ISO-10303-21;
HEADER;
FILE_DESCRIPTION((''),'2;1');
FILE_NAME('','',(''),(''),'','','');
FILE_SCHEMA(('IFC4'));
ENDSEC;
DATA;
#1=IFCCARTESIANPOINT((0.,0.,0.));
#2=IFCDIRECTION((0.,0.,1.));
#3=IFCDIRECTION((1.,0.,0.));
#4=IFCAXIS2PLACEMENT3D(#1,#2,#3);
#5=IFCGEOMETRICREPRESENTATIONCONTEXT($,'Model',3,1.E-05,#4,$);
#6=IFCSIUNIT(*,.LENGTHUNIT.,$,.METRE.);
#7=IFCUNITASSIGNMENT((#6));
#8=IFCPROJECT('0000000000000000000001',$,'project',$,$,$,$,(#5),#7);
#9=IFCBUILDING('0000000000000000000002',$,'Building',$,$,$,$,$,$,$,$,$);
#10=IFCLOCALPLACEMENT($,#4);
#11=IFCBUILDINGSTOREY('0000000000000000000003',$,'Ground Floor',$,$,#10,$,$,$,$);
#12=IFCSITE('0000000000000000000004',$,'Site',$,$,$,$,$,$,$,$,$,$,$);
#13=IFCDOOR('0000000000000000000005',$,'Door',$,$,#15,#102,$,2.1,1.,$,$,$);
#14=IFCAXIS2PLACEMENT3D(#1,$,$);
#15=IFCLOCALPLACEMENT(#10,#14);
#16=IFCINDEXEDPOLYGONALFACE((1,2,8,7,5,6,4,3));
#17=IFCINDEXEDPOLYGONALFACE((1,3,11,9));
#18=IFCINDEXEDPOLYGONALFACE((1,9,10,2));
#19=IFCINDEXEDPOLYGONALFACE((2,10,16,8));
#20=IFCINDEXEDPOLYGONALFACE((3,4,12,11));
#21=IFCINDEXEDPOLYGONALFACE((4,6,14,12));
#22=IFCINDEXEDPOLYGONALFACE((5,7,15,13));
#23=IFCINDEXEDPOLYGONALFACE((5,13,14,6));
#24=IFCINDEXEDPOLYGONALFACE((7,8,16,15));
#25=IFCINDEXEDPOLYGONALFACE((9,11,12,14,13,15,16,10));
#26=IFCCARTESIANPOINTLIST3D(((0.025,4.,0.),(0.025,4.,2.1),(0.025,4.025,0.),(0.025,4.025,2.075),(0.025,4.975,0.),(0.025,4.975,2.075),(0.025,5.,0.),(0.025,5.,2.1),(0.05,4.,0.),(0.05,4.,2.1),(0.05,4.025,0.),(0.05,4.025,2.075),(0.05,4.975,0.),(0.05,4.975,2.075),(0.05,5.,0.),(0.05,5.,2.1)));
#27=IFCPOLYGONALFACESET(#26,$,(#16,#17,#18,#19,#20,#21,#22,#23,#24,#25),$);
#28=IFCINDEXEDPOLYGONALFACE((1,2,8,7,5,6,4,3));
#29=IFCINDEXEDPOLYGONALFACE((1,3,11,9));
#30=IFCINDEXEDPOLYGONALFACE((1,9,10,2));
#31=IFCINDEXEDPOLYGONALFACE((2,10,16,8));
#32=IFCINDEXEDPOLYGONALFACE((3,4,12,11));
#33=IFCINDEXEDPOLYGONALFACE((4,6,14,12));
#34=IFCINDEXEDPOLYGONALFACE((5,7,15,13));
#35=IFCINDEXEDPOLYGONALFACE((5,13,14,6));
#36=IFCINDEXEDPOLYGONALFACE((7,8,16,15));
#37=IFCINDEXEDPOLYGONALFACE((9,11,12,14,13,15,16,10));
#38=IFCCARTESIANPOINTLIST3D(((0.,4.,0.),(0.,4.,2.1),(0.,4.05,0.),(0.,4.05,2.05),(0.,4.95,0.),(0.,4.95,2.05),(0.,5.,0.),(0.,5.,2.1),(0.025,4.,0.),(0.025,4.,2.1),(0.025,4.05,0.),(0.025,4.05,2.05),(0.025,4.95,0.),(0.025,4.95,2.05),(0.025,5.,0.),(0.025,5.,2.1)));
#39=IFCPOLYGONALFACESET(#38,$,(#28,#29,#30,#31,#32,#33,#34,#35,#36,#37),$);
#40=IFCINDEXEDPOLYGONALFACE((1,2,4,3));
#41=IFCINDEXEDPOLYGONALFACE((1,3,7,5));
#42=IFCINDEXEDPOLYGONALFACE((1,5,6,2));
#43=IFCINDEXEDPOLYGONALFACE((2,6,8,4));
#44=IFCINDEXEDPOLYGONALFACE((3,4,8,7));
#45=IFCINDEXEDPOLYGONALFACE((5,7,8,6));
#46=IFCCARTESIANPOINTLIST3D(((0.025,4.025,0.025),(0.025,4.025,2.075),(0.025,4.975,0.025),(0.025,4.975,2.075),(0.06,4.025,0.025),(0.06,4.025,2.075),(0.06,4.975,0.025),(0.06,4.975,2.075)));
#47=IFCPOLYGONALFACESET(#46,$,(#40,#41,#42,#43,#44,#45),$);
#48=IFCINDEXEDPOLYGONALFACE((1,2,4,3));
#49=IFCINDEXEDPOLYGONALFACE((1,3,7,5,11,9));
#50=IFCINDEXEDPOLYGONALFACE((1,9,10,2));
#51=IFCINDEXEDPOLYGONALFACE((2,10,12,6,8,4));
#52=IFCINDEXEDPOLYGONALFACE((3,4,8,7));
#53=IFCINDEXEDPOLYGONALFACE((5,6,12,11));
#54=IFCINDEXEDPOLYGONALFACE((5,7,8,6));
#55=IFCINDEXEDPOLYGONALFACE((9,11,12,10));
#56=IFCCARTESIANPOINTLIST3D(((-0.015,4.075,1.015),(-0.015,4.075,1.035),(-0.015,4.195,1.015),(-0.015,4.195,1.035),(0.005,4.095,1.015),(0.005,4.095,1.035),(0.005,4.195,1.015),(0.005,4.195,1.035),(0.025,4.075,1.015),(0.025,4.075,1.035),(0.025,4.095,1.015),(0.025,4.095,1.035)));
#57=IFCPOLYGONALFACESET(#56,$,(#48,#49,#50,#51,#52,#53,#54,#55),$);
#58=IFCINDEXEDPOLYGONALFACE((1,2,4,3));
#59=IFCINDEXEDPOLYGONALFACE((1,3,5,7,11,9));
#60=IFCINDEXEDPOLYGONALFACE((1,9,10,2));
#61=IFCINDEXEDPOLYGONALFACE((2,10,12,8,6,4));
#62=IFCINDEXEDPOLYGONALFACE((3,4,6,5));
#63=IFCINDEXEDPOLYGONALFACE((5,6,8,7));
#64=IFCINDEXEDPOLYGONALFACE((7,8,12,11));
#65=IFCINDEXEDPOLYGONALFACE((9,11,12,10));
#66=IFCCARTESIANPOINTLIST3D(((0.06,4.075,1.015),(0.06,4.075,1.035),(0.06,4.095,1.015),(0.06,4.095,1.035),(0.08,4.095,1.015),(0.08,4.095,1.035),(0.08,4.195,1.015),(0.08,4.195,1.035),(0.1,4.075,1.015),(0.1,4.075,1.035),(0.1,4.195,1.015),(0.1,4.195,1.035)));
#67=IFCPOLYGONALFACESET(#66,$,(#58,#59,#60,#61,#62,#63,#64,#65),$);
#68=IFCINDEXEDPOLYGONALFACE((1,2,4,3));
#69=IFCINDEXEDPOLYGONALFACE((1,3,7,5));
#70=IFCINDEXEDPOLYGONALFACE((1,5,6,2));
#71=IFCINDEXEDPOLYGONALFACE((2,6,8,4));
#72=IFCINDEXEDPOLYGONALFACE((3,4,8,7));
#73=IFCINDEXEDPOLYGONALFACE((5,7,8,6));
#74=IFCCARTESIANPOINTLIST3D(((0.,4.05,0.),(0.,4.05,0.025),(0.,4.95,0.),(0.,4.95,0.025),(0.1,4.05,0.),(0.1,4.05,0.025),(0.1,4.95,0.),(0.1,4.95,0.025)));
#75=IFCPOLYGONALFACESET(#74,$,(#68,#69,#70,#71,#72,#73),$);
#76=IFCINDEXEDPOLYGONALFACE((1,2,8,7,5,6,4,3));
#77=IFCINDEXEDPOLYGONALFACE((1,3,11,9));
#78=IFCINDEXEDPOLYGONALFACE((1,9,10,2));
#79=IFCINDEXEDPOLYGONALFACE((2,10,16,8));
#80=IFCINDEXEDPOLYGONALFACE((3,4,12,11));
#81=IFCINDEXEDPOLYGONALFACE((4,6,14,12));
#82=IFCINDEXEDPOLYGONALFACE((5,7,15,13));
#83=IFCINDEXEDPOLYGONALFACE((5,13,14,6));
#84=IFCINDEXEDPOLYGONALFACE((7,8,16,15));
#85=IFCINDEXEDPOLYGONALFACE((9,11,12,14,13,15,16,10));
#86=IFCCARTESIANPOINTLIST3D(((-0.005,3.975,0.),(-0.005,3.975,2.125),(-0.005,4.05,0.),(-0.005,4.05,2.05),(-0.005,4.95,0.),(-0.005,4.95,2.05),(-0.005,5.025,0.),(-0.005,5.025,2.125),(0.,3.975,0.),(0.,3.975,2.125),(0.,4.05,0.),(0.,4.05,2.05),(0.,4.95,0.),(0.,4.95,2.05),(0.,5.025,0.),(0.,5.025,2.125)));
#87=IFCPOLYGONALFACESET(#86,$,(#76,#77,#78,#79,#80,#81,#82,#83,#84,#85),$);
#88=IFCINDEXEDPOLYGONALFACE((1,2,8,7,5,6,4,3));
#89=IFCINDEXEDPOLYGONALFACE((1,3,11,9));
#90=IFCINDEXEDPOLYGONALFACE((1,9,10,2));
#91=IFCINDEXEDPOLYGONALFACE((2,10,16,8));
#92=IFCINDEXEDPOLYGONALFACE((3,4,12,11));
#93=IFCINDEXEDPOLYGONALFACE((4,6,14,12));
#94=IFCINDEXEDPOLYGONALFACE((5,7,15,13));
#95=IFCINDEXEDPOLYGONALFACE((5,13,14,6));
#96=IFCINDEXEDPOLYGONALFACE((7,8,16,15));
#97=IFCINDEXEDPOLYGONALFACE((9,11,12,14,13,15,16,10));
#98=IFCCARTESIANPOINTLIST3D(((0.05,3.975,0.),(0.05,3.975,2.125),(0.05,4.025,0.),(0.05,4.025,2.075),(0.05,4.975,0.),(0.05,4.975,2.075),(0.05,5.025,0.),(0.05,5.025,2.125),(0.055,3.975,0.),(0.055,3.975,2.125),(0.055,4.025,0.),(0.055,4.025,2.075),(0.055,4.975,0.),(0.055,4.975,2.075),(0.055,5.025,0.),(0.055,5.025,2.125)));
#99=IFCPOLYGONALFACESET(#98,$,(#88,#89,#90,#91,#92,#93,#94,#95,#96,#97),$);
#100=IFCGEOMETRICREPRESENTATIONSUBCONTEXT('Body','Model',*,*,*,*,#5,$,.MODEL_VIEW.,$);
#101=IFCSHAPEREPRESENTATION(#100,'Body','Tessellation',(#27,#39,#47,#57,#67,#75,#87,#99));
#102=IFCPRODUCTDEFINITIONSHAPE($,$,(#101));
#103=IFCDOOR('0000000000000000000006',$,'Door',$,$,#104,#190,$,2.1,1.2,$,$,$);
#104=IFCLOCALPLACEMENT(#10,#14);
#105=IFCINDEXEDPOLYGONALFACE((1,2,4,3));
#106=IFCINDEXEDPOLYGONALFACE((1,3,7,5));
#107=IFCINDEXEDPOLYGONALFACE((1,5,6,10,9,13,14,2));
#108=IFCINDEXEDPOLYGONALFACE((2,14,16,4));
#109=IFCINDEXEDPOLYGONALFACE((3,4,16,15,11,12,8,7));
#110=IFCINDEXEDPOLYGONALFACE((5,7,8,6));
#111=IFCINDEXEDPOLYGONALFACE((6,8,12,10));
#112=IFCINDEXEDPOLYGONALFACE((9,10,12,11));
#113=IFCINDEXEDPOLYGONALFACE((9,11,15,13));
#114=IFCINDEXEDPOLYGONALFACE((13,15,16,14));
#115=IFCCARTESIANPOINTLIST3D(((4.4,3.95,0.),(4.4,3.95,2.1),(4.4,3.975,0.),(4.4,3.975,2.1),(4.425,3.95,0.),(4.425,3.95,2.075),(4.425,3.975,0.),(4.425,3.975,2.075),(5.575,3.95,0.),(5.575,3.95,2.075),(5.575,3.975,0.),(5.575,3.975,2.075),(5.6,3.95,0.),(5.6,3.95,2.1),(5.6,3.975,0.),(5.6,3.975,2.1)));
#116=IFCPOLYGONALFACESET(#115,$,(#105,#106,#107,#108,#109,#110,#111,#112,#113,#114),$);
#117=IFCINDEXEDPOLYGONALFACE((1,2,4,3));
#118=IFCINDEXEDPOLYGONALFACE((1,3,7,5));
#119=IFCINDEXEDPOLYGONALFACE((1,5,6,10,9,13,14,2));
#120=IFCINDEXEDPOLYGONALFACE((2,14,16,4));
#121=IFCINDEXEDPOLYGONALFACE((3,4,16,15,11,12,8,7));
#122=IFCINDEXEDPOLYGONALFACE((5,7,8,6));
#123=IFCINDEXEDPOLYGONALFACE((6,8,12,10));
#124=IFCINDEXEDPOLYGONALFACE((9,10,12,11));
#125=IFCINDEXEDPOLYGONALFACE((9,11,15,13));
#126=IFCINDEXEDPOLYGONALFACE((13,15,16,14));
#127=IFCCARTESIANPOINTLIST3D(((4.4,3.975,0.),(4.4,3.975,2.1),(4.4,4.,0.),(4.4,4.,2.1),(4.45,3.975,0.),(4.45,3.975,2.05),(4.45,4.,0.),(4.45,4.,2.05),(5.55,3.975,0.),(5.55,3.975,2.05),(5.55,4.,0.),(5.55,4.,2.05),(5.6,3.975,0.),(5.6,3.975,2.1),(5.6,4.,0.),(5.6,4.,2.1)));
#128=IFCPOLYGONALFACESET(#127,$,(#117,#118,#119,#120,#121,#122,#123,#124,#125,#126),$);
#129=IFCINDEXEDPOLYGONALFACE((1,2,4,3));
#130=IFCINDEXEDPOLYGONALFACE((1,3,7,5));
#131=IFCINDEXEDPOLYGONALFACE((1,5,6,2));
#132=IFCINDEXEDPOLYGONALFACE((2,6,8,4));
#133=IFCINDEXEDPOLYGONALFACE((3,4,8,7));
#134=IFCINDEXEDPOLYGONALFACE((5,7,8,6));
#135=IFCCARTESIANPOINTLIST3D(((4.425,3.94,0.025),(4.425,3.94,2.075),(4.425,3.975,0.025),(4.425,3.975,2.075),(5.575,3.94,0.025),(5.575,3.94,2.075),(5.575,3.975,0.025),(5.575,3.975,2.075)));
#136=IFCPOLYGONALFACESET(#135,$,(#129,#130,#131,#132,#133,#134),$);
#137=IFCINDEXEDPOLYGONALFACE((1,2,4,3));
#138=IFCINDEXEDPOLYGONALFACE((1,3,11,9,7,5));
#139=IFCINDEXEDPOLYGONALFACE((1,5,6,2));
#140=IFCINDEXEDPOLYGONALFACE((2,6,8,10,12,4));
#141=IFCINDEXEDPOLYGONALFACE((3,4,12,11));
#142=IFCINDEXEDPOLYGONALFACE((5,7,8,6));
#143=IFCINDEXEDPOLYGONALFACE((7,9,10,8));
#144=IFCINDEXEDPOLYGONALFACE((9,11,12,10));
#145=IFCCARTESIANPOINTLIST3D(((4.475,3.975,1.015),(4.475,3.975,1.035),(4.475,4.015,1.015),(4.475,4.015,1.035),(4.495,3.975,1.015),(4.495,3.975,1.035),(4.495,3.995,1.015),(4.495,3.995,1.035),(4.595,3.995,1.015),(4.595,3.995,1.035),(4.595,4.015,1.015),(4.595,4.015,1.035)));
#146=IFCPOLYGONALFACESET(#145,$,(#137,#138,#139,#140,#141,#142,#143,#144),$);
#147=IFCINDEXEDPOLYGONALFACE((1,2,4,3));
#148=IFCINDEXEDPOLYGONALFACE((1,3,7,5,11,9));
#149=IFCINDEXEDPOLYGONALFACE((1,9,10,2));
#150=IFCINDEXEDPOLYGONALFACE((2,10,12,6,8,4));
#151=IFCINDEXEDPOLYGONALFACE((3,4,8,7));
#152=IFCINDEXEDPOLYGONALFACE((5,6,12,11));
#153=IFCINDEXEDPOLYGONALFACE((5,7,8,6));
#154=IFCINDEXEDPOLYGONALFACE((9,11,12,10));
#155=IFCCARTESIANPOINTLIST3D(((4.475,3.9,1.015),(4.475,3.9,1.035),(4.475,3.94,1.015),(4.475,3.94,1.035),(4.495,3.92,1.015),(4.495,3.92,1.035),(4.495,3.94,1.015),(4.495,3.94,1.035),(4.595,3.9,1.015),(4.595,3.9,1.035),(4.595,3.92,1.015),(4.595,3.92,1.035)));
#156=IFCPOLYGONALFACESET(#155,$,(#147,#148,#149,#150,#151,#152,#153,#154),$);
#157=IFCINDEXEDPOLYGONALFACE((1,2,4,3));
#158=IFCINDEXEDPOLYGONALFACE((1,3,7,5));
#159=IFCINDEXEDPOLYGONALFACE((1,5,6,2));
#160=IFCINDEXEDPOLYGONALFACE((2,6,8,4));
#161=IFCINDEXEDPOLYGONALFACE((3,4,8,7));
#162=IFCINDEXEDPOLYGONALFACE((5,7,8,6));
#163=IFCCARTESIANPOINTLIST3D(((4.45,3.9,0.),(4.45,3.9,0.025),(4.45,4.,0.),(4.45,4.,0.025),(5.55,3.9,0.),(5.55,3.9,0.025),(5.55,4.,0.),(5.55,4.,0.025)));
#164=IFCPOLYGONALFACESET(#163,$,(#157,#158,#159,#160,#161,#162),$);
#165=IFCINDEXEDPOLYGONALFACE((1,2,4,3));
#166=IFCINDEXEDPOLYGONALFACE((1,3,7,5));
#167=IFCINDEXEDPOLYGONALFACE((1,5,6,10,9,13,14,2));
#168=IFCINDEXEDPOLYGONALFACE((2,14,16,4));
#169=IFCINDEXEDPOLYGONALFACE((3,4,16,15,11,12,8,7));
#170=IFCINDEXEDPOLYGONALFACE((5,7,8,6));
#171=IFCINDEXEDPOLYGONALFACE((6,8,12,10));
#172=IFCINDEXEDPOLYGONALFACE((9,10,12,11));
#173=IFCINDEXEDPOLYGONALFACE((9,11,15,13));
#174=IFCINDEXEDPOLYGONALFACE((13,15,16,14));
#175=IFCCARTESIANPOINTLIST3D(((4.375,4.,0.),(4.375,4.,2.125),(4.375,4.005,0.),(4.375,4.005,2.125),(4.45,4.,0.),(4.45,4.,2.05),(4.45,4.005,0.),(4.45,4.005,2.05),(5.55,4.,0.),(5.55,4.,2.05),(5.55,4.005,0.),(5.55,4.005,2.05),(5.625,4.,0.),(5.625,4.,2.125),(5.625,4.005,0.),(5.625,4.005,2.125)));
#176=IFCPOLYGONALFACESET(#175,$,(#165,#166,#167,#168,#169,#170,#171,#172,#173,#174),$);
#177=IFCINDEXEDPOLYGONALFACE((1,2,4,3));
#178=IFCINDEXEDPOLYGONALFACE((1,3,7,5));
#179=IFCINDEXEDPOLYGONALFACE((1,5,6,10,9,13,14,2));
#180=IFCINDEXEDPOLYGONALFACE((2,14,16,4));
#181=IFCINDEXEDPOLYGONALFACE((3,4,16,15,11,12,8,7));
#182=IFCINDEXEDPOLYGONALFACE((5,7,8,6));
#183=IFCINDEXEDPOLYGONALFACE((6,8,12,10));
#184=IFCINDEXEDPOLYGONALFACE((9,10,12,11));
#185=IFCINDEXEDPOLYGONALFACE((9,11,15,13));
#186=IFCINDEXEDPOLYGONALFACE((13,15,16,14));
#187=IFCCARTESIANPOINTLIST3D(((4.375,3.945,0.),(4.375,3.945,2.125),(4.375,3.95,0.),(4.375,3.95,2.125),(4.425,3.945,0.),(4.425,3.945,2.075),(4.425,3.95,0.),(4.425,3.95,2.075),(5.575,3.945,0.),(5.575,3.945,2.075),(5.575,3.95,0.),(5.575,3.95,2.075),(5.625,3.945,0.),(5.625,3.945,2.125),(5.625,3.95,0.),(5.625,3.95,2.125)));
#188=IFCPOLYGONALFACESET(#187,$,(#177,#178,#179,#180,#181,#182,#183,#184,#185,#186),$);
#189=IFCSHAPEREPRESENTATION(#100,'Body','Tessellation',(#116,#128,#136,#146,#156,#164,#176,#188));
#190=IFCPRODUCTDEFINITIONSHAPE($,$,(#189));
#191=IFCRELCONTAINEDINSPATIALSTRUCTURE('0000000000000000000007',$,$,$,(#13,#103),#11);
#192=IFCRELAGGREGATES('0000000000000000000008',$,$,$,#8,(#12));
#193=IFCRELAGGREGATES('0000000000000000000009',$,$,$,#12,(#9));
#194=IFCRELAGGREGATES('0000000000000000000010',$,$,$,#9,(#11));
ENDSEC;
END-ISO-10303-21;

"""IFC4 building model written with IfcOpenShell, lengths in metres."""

from ifc_helpers import new_model, si_unit, frame, origin_with_axes, place, context, subcontext, project, spatial, line, indexed_curve, outline, extrude, element, save


model = new_model("IFC4")

# Units and contexts
model_context = context("Model", 3, precision=1e-05, world=origin_with_axes())
body_context = subcontext(model_context, "Body", "Model", "MODEL_VIEW")
ifc_project = project(units=[si_unit("LENGTHUNIT", "METRE")], contexts=[model_context])

# Site, building, storey
site = spatial("IfcSite", under=ifc_project, Name="Site")
building = spatial("IfcBuilding", under=site, Name="Building")
storey_placement = place(None, origin_with_axes())
storey = spatial("IfcBuildingStorey", under=building, at=storey_placement, Name="Ground Floor")

# Doors
door_1_placement = place(storey_placement, frame((0.0, 5.0, 0.0), z_axis=(0.0, 0.0, 1.0), x_axis=(0.0, -1.0, 0.0)))
element("IfcDoor", 1, at=door_1_placement, inside=storey, Name="Door", OverallHeight=2.1, OverallWidth=1.0, context=body_context, shape_type="SweptSolid", body=[
    extrude(outline(indexed_curve([(0.0, 0.0), (0.0, 2.1), (1.0, 2.1), (1.0, 0.0), (0.975, 0.0), (0.975, 2.075), (0.025, 2.075), (0.025, 0.0)], segments=[line(1, 2, 3, 4, 5, 6, 7, 8, 1)])), frame((0.0, 0.025, 0.0), z_axis=(0.0, -1.0, 0.0), x_axis=(1.0, 0.0, 0.0)), (0.0, 0.0, -1.0), 0.025),
    extrude(outline(indexed_curve([(0.0, 0.0), (0.0, 2.1), (1.0, 2.1), (1.0, 0.0), (0.95, 0.0), (0.95, 2.05), (0.05, 2.05), (0.05, 0.0)], segments=[line(1, 2, 3, 4, 5, 6, 7, 8, 1)])), frame((0.0, 0.0, 0.0), z_axis=(0.0, -1.0, 0.0), x_axis=(1.0, 0.0, 0.0)), (0.0, 0.0, -1.0), 0.025),
    extrude(outline(indexed_curve([(0.0, 0.0), (0.95, 0.0), (0.95, 0.035), (0.0, 0.035)], segments=[line(1, 2, 3, 4, 1)])), frame((0.025, 0.025, 0.025), z_axis=(0.0, 0.0, 1.0), x_axis=(1.0, 0.0, 0.0)), (0.0, 0.0, 1.0), 2.05),
    extrude(outline(indexed_curve([(0.0, 0.0), (0.0, -0.04), (-0.12, -0.04), (-0.12, -0.02), (-0.02, -0.02), (-0.02, 0.0)], segments=[line(1, 2, 3, 4, 5, 6, 1)])), frame((0.925, 0.025, 1.015), z_axis=(0.0, 0.0, 1.0), x_axis=(1.0, 0.0, 0.0)), (0.0, 0.0, 1.0), 0.02),
    extrude(outline(indexed_curve([(0.0, 0.0), (0.0, 0.04), (-0.12, 0.04), (-0.12, 0.02), (-0.02, 0.02), (-0.02, 0.0)], segments=[line(1, 2, 3, 4, 5, 6, 1)])), frame((0.925, 0.06, 1.015), z_axis=(0.0, 0.0, 1.0), x_axis=(1.0, 0.0, 0.0)), (0.0, 0.0, 1.0), 0.02),
    extrude(outline(indexed_curve([(0.0, 0.0), (0.9, 0.0), (0.9, 0.1), (0.0, 0.1)], segments=[line(1, 2, 3, 4, 1)])), frame((0.05, 0.0, 0.0), z_axis=(0.0, 0.0, 1.0), x_axis=(1.0, 0.0, 0.0)), (0.0, 0.0, 1.0), 0.025),
    extrude(outline(indexed_curve([(0.0, 0.0), (0.0, 2.125), (1.05, 2.125), (1.05, 0.0), (0.975, 0.0), (0.975, 2.05), (0.075, 2.05), (0.075, 0.0)], segments=[line(1, 2, 3, 4, 5, 6, 7, 8, 1)])), frame((-0.025, -0.005, 0.0), z_axis=(0.0, -1.0, 0.0), x_axis=(1.0, 0.0, 0.0)), (0.0, 0.0, -1.0), 0.005),
    extrude(outline(indexed_curve([(0.0, 0.0), (0.0, 2.125), (1.05, 2.125), (1.05, 0.0), (1.0, 0.0), (1.0, 2.075), (0.05, 2.075), (0.05, 0.0)], segments=[line(1, 2, 3, 4, 5, 6, 7, 8, 1)])), frame((-0.025, 0.05, 0.0), z_axis=(0.0, -1.0, 0.0), x_axis=(1.0, 0.0, 0.0)), (0.0, 0.0, -1.0), 0.005),
])
door_2_placement = place(storey_placement, frame((5.6, 4.0, 0.0), z_axis=(0.0, 0.0, 1.0), x_axis=(-1.0, 0.0, 0.0)))
element("IfcDoor", 2, at=door_2_placement, inside=storey, Name="Door", OverallHeight=2.1, OverallWidth=1.2, context=body_context, shape_type="SweptSolid", body=[
    extrude(outline(indexed_curve([(0.0, 0.0), (0.0, 2.1), (1.2, 2.1), (1.2, 0.0), (1.175, 0.0), (1.175, 2.075), (0.025, 2.075), (0.025, 0.0)], segments=[line(1, 2, 3, 4, 5, 6, 7, 8, 1)])), frame((0.0, 0.025, 0.0), z_axis=(0.0, -1.0, 0.0), x_axis=(1.0, 0.0, 0.0)), (0.0, 0.0, -1.0), 0.025),
    extrude(outline(indexed_curve([(0.0, 0.0), (0.0, 2.1), (1.2, 2.1), (1.2, 0.0), (1.15, 0.0), (1.15, 2.05), (0.05, 2.05), (0.05, 0.0)], segments=[line(1, 2, 3, 4, 5, 6, 7, 8, 1)])), frame((0.0, 0.0, 0.0), z_axis=(0.0, -1.0, 0.0), x_axis=(1.0, 0.0, 0.0)), (0.0, 0.0, -1.0), 0.025),
    extrude(outline(indexed_curve([(0.0, 0.0), (1.15, 0.0), (1.15, 0.035), (0.0, 0.035)], segments=[line(1, 2, 3, 4, 1)])), frame((0.025, 0.025, 0.025), z_axis=(0.0, 0.0, 1.0), x_axis=(1.0, 0.0, 0.0)), (0.0, 0.0, 1.0), 2.05),
    extrude(outline(indexed_curve([(0.0, 0.0), (0.0, -0.04), (-0.12, -0.04), (-0.12, -0.02), (-0.02, -0.02), (-0.02, 0.0)], segments=[line(1, 2, 3, 4, 5, 6, 1)])), frame((1.125, 0.025, 1.015), z_axis=(0.0, 0.0, 1.0), x_axis=(1.0, 0.0, 0.0)), (0.0, 0.0, 1.0), 0.02),
    extrude(outline(indexed_curve([(0.0, 0.0), (0.0, 0.04), (-0.12, 0.04), (-0.12, 0.02), (-0.02, 0.02), (-0.02, 0.0)], segments=[line(1, 2, 3, 4, 5, 6, 1)])), frame((1.125, 0.06, 1.015), z_axis=(0.0, 0.0, 1.0), x_axis=(1.0, 0.0, 0.0)), (0.0, 0.0, 1.0), 0.02),
    extrude(outline(indexed_curve([(0.0, 0.0), (1.1, 0.0), (1.1, 0.1), (0.0, 0.1)], segments=[line(1, 2, 3, 4, 1)])), frame((0.05, 0.0, 0.0), z_axis=(0.0, 0.0, 1.0), x_axis=(1.0, 0.0, 0.0)), (0.0, 0.0, 1.0), 0.025),
    extrude(outline(indexed_curve([(0.0, 0.0), (0.0, 2.125), (1.25, 2.125), (1.25, 0.0), (1.175, 0.0), (1.175, 2.05), (0.075, 2.05), (0.075, 0.0)], segments=[line(1, 2, 3, 4, 5, 6, 7, 8, 1)])), frame((-0.025, -0.005, 0.0), z_axis=(0.0, -1.0, 0.0), x_axis=(1.0, 0.0, 0.0)), (0.0, 0.0, -1.0), 0.005),
    extrude(outline(indexed_curve([(0.0, 0.0), (0.0, 2.125), (1.25, 2.125), (1.25, 0.0), (1.2, 0.0), (1.2, 2.075), (0.05, 2.075), (0.05, 0.0)], segments=[line(1, 2, 3, 4, 5, 6, 7, 8, 1)])), frame((-0.025, 0.05, 0.0), z_axis=(0.0, -1.0, 0.0), x_axis=(1.0, 0.0, 0.0)), (0.0, 0.0, -1.0), 0.005),
])

save(model, "model.ifc")
